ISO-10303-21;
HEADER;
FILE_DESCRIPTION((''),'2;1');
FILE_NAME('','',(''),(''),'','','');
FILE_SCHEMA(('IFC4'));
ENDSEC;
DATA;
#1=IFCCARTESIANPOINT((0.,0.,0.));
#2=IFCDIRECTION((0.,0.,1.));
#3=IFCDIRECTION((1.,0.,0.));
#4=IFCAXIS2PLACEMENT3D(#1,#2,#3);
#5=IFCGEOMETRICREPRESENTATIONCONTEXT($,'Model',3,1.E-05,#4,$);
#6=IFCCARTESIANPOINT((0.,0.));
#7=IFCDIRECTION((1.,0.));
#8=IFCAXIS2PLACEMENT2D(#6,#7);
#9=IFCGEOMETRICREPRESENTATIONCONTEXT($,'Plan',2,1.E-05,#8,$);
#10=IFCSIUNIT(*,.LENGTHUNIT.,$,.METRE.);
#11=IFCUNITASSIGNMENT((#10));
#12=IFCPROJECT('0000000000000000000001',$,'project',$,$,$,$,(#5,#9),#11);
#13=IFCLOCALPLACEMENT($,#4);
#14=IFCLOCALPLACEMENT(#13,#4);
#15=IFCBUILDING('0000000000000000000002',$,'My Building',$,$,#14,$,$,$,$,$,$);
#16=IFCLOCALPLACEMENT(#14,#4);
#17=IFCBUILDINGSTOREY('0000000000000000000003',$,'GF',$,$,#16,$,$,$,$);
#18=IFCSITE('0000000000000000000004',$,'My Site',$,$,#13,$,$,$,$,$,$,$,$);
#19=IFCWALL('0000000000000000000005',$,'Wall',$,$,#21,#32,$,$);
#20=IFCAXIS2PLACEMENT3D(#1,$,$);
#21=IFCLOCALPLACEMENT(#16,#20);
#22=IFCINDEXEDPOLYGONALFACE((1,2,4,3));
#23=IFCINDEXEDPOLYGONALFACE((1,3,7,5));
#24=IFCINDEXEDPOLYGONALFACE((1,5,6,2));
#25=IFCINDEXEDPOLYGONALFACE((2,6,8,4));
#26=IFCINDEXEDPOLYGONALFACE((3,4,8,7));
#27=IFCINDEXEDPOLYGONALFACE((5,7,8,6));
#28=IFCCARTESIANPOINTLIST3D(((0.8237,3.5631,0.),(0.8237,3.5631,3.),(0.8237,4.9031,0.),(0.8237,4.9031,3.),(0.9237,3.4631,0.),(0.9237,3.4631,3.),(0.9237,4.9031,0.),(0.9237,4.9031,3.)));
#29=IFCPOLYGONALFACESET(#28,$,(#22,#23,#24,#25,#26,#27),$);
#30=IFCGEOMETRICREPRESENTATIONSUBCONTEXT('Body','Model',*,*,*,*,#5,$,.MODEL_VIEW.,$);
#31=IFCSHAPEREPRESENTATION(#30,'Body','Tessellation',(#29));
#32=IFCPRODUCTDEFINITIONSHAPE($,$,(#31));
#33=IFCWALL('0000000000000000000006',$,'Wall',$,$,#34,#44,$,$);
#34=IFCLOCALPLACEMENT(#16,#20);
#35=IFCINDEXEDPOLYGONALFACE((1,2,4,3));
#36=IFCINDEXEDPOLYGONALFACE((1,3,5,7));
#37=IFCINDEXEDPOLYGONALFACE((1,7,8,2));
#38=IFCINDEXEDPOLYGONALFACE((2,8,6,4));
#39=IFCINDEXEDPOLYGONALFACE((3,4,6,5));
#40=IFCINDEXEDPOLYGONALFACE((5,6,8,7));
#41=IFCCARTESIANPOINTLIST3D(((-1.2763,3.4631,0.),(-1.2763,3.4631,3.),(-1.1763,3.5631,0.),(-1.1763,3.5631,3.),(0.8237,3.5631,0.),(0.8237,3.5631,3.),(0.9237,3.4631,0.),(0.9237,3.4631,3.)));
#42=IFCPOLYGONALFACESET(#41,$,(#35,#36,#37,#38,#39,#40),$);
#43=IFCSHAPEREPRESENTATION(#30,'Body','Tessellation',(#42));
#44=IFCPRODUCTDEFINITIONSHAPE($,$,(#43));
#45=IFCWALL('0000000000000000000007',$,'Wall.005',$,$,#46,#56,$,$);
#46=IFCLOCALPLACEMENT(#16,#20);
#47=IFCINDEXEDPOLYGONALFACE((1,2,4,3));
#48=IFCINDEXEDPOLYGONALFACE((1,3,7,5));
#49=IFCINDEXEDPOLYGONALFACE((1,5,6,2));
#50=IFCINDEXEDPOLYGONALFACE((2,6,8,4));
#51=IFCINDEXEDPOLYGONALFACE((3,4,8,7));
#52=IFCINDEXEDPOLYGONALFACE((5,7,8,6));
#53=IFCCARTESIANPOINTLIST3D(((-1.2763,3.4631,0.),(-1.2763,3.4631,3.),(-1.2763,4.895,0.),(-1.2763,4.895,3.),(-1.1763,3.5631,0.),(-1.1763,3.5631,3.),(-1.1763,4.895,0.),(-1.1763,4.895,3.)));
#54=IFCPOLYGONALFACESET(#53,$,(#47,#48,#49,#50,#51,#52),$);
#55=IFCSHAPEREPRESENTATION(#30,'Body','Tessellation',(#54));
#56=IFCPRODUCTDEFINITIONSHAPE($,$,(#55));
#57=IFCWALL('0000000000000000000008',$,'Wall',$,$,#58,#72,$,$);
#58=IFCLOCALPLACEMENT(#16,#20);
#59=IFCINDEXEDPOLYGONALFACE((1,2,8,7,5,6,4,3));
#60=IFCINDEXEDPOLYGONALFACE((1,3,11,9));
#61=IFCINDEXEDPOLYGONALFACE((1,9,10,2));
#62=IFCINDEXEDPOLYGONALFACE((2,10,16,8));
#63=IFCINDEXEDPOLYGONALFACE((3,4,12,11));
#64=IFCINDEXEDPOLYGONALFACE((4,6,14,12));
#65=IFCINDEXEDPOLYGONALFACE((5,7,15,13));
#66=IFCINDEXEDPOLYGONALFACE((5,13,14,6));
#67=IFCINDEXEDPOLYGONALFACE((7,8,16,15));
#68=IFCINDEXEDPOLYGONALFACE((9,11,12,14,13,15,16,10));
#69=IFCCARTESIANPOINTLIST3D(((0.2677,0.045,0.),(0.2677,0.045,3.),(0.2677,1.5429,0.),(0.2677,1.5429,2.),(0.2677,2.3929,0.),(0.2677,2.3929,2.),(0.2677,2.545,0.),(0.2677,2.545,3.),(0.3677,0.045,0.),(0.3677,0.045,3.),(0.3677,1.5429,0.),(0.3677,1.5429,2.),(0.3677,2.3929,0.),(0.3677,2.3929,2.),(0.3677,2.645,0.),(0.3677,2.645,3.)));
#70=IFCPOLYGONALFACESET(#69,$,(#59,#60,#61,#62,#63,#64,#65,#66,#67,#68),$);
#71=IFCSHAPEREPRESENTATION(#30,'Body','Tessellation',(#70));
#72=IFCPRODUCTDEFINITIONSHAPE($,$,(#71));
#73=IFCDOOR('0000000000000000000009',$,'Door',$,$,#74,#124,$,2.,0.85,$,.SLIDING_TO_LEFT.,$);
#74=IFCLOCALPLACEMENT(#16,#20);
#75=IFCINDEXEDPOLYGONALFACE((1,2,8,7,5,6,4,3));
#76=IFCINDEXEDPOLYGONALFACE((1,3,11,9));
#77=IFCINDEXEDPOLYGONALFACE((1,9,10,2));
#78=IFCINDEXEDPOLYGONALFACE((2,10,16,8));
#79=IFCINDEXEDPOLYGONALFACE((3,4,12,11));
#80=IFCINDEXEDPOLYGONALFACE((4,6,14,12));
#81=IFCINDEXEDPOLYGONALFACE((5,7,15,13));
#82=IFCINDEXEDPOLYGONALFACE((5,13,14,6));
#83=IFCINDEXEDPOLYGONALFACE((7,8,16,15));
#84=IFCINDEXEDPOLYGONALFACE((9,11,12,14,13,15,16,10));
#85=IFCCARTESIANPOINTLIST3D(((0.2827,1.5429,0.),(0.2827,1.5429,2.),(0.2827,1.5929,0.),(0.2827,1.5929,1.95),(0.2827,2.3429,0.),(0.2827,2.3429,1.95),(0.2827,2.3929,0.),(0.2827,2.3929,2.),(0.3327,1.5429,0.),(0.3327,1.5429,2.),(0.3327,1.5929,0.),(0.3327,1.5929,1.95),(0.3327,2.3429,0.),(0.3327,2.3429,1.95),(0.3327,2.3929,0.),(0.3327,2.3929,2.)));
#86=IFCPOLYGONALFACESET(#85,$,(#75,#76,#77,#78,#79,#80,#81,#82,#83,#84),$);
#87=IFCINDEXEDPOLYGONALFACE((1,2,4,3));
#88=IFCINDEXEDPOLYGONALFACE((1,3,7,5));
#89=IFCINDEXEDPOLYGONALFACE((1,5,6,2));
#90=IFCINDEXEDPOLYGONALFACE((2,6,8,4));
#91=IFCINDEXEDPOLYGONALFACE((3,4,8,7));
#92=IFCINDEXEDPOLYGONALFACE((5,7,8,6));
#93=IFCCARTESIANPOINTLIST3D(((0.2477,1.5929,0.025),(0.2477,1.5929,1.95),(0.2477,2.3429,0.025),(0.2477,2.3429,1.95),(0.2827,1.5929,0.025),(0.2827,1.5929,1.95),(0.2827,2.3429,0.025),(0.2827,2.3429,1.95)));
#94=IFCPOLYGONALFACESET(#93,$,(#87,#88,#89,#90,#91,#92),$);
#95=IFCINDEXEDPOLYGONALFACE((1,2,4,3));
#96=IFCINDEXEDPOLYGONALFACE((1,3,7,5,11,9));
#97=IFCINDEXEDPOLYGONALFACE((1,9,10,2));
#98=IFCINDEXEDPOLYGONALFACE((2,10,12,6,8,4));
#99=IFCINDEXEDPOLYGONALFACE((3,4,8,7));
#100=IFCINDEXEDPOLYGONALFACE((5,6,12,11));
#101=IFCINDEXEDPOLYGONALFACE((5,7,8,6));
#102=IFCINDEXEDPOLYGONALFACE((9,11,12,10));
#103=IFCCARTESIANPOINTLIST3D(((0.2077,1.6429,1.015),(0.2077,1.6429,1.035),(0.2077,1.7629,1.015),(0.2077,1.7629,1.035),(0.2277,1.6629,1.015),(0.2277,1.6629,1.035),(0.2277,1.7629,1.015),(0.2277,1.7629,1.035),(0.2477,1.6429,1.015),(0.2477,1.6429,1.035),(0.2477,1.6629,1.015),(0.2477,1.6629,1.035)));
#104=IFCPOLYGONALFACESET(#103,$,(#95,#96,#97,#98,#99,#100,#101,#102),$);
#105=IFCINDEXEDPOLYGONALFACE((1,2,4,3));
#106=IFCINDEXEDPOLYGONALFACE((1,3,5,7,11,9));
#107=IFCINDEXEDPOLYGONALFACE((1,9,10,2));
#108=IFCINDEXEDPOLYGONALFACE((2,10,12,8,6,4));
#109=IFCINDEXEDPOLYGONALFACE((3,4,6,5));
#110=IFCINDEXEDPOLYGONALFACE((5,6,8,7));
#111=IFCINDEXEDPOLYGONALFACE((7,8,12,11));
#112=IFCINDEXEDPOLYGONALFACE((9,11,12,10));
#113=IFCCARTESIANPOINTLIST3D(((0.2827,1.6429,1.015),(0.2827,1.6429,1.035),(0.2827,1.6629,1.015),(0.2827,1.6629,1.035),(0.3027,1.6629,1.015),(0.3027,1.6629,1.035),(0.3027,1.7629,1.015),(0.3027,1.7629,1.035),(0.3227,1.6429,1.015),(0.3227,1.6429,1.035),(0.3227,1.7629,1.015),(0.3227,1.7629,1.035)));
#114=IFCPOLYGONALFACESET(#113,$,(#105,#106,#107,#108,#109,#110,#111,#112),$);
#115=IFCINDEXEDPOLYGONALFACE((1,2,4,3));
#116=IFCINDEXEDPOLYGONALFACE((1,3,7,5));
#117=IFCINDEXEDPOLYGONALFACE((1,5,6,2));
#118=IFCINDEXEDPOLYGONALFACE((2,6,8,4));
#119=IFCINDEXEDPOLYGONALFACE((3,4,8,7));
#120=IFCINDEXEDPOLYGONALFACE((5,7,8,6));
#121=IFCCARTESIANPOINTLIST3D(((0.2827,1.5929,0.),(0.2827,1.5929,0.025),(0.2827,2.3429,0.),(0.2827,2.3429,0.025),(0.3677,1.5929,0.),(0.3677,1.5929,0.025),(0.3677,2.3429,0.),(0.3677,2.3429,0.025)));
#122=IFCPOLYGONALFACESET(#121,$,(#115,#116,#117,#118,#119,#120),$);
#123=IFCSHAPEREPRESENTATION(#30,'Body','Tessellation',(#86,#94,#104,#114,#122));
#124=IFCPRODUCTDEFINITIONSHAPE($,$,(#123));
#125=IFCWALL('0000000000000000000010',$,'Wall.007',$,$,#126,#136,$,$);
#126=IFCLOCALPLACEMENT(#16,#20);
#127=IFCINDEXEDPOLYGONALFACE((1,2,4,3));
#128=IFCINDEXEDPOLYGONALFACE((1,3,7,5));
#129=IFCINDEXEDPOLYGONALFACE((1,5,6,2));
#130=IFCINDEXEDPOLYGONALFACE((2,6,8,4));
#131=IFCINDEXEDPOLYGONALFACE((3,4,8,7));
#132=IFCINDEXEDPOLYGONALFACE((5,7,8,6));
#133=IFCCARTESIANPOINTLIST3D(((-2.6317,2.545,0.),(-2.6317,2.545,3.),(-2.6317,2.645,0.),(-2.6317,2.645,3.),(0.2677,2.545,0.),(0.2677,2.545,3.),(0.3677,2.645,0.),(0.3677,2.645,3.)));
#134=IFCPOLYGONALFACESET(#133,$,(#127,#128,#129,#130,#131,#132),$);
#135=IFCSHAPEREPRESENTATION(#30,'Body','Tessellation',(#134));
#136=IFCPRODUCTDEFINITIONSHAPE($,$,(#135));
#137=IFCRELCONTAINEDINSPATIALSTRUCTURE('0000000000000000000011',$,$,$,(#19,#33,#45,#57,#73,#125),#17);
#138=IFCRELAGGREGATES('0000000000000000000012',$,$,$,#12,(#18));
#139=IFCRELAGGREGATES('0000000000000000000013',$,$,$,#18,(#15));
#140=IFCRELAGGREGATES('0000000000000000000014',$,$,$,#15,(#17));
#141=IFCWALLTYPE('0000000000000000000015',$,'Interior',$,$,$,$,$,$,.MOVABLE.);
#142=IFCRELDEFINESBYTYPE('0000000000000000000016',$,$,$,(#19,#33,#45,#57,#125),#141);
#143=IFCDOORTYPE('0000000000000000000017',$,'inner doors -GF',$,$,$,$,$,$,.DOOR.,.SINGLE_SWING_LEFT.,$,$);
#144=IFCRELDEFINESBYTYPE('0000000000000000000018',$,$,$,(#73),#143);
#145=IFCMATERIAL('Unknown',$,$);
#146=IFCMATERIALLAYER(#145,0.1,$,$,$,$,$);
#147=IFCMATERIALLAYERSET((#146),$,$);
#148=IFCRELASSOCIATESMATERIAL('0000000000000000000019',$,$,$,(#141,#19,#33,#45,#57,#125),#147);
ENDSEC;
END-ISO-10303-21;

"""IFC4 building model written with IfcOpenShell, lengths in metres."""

from ifc_helpers import new_model, entity, si_unit, frame, origin_with_axes, origin_2d_with_axis, place, context, subcontext, project, spatial, line, indexed_curve, outline, extrude, shape, source, transform, mapped, material, layer, layer_set, layer_usage, type_object, type_shapes, element, fill, save


model = new_model("IFC4")

# Units and contexts
model_context = context("Model", 3, precision=1e-05, world=origin_with_axes())
plan_context = context("Plan", 2, precision=1e-05, world=origin_2d_with_axis())
body_context_1 = subcontext(model_context, "Body", "Model", "MODEL_VIEW")
body_context_2 = subcontext(plan_context, "Body", "Plan", "PLAN_VIEW")
ifc_project = project(units=[si_unit("LENGTHUNIT", "METRE")], contexts=[model_context, plan_context])

# Site, building, storey
site_placement = place(None, origin_with_axes())
site = spatial("IfcSite", under=ifc_project, at=site_placement, Name="My Site")
building_placement = place(site_placement, origin_with_axes())
building = spatial("IfcBuilding", under=site, at=building_placement, Name="My Building")
storey_placement = place(building_placement, origin_with_axes())
storey = spatial("IfcBuildingStorey", under=building, at=storey_placement, Name="GF")

# Shared definitions
ifc_material = material(Name="Unknown")

# Walls
ifc_layer_1 = layer(ifc_material, 0.1)
ifc_layer_set_1 = layer_set([ifc_layer_1])
ifc_layer_usage_1 = layer_usage(ifc_layer_set_1, "AXIS2", "POSITIVE", 0.0)
wall_type_1 = type_object("IfcWallType", Name="Interior", PredefinedType="MOVABLE", material=ifc_layer_set_1)
wall_1_placement = place(storey_placement, frame((0.8237, 4.9031, 0.0), z_axis=(0.0, 0.0, 1.0), x_axis=(0.0, -1.0, 0.0)))
element("IfcWall", 1, at=wall_1_placement, inside=storey, type_object=wall_type_1, material=ifc_layer_usage_1, Name="Wall", context=body_context_1, shape_type="SweptSolid", body=[
    extrude(outline(indexed_curve([(0.0, 0.0), (0.0, 0.1), (1.44, 0.1), (1.34, 0.0)], segments=[line(1, 2, 3, 4, 1)])), origin_with_axes(), (0.0, 0.0, 1.0), 3.0),
])
ifc_layer_usage_2 = layer_usage(ifc_layer_set_1, "AXIS2", "POSITIVE", 0.0)
wall_2_placement = place(storey_placement, frame((0.8237, 3.5631, 0.0), z_axis=(0.0, 0.0, 1.0), x_axis=(-1.0, 0.0, 0.0)))
element("IfcWall", 2, at=wall_2_placement, inside=storey, type_object=wall_type_1, material=ifc_layer_usage_2, Name="Wall", context=body_context_1, shape_type="SweptSolid", body=[
    extrude(outline(indexed_curve([(0.0, 0.0), (-0.1, 0.1), (2.1, 0.1), (2.0, 0.0)], segments=[line(1, 2, 3, 4, 1)])), origin_with_axes(), (0.0, 0.0, 1.0), 3.0),
])
ifc_layer_usage_3 = layer_usage(ifc_layer_set_1, "AXIS2", "POSITIVE", 0.0)
wall_3_placement = place(storey_placement, frame((-1.1763, 3.5631, 0.0), z_axis=(0.0, 0.0, 1.0), x_axis=(0.0, 1.0, 0.0)))
element("IfcWall", 3, at=wall_3_placement, inside=storey, type_object=wall_type_1, material=ifc_layer_usage_3, Name="Wall.005", context=body_context_1, shape_type="SweptSolid", body=[
    extrude(outline(indexed_curve([(0.0, 0.0), (-0.1, 0.1), (1.3318, 0.1), (1.3318, 0.0)], segments=[line(1, 2, 3, 4, 1)])), origin_with_axes(), (0.0, 0.0, 1.0), 3.0),
])

# Wall, opening, door
ifc_layer_usage_4 = layer_usage(ifc_layer_set_1, "AXIS2", "POSITIVE", 0.0)
wall_4_placement = place(storey_placement, frame((0.3677, 0.045, 0.0), z_axis=(0.0, 0.0, 1.0), x_axis=(0.0, 1.0, 0.0)))
wall_4 = element("IfcWall", 4, at=wall_4_placement, inside=storey, type_object=wall_type_1, material=ifc_layer_usage_4, Name="Wall", context=body_context_1, shape_type="SweptSolid", body=[
    extrude(outline(indexed_curve([(0.0, 0.0), (0.0, 0.1), (2.5, 0.1), (2.6, 0.0)], segments=[line(1, 2, 3, 4, 1)])), origin_with_axes(), (0.0, 0.0, 1.0), 3.0),
])
shared_shape_1 = source(origin_with_axes(), body_context_1, "Body", "SweptSolid", [
    extrude(outline(indexed_curve([(0.0, 0.0), (0.85, 0.0), (0.85, 2.0), (0.0, 2.0)], segments=[line(1, 2, 3, 4, 1)])), frame((0.0, -0.6, 0.0), z_axis=(0.0, -1.0, 0.0), x_axis=(1.0, 0.0, 0.0)), (0.0, 0.0, -1.0), 1.2),
])
opening_1_placement = place(wall_4_placement, frame((2.3479, 0.1, 0.0), z_axis=(0.0, 0.0, 1.0), x_axis=(-1.0, 0.0, 0.0)))
opening_1 = element("IfcOpeningElement", 5, at=opening_1_placement, cuts=wall_4, PredefinedType="OPENING", context=body_context_1, shape_type="MappedRepresentation", body=[
    mapped(shared_shape_1, transform((0.0, 0.0, 0.0), x_axis=(1.0, 0.0, 0.0), y_axis=(0.0, 1.0, 0.0), z_axis=(0.0, 0.0, 1.0), scale=1.0)),
])
door_type_1 = type_object("IfcDoorType", Name="inner doors -GF", OperationType="SINGLE_SWING_LEFT", PredefinedType="DOOR")
shared_shape_2 = source(origin_with_axes(), body_context_1, "Body", "SweptSolid", [
    extrude(outline(indexed_curve([(0.0, 0.0), (0.0, 2.0), (0.85, 2.0), (0.85, 0.0), (0.8, 0.0), (0.8, 1.95), (0.05, 1.95), (0.05, 0.0)], segments=[line(1, 2, 3, 4, 5, 6, 7, 8, 1)])), frame((0.0, 0.0, 0.0), z_axis=(0.0, -1.0, 0.0), x_axis=(1.0, 0.0, 0.0)), (0.0, 0.0, -1.0), 0.05),
    extrude(outline(indexed_curve([(0.0, 0.0), (0.75, 0.0), (0.75, 0.035), (0.0, 0.035)], segments=[line(1, 2, 3, 4, 1)])), frame((0.05, -0.035, 0.025), z_axis=(0.0, 0.0, 1.0), x_axis=(1.0, 0.0, 0.0)), (0.0, 0.0, 1.0), 1.925),
    extrude(outline(indexed_curve([(0.0, 0.0), (0.0, -0.04), (-0.12, -0.04), (-0.12, -0.02), (-0.02, -0.02), (-0.02, 0.0)], segments=[line(1, 2, 3, 4, 5, 6, 1)])), frame((0.75, -0.035, 1.015), z_axis=(0.0, 0.0, 1.0), x_axis=(1.0, 0.0, 0.0)), (0.0, 0.0, 1.0), 0.02),
    extrude(outline(indexed_curve([(0.0, 0.0), (0.0, 0.04), (-0.12, 0.04), (-0.12, 0.02), (-0.02, 0.02), (-0.02, 0.0)], segments=[line(1, 2, 3, 4, 5, 6, 1)])), frame((0.75, 0.0, 1.015), z_axis=(0.0, 0.0, 1.0), x_axis=(1.0, 0.0, 0.0)), (0.0, 0.0, 1.0), 0.02),
    extrude(outline(indexed_curve([(0.0, 0.0), (0.75, 0.0), (0.75, 0.085), (0.0, 0.085)], segments=[line(1, 2, 3, 4, 1)])), frame((0.05, 0.0, 0.0), z_axis=(0.0, 0.0, 1.0), x_axis=(1.0, 0.0, 0.0)), (0.0, 0.0, 1.0), 0.025),
])
shared_shape_3 = source(origin_with_axes(), body_context_2, "Body", "Curve2D", [
    entity("IfcIndexedPolyCurve", entity("IfcCartesianPointList2D", [[0.0, 0.0], [0.05, 0.0], [0.05, 0.05], [0.0, 0.05]]), [entity("IfcLineIndex", [1, 2, 3, 4, 1])]),
    entity("IfcIndexedPolyCurve", entity("IfcCartesianPointList2D", [[0.85, 0.0], [0.8, 0.0], [0.8, 0.05], [0.85, 0.05]]), [entity("IfcLineIndex", [1, 2, 3, 4, 1])]),
    entity("IfcIndexedPolyCurve", entity("IfcCartesianPointList2D", [[-0.325, -0.035], [0.425, -0.035], [0.425, 0.0], [-0.325, 0.0]]), [entity("IfcLineIndex", [1, 2, 3, 4, 1])]),
])
type_shapes(door_type_1, [shared_shape_2, shared_shape_3])
door_1_placement = place(opening_1_placement, frame((0.0, 0.015, 0.0), z_axis=(0.0, 0.0, 1.0), x_axis=(1.0, 0.0, 0.0)))
door_1 = element("IfcDoor", 6, at=door_1_placement, inside=storey, type_object=door_type_1, Name="Door", OperationType="SLIDING_TO_LEFT", OverallHeight=2.0, OverallWidth=0.85, shapes=[
    shape(body_context_1, "Body", "MappedRepresentation", [mapped(shared_shape_2, transform((0.0, 0.0, 0.0), x_axis=(1.0, 0.0, 0.0), y_axis=(0.0, 1.0, 0.0), z_axis=(0.0, 0.0, 1.0), scale=1.0))]),
    shape(body_context_2, "Body", "MappedRepresentation", [mapped(shared_shape_3, transform((0.0, 0.0, 0.0), x_axis=(1.0, 0.0, 0.0), y_axis=(0.0, 1.0, 0.0), z_axis=(0.0, 0.0, 1.0), scale=1.0))]),
])
fill(opening_1, door_1)

# Wall
ifc_layer_usage_5 = layer_usage(ifc_layer_set_1, "AXIS2", "POSITIVE", 0.0)
wall_5_placement = place(storey_placement, frame((0.3677, 2.645, 0.0), z_axis=(0.0, 0.0, 1.0), x_axis=(-1.0, 0.0, 0.0)))
element("IfcWall", 7, at=wall_5_placement, inside=storey, type_object=wall_type_1, material=ifc_layer_usage_5, Name="Wall.007", context=body_context_1, shape_type="SweptSolid", body=[
    extrude(outline(indexed_curve([(0.0, 0.0), (0.1, 0.1), (2.9994, 0.1), (2.9994, 0.0)], segments=[line(1, 2, 3, 4, 1)])), origin_with_axes(), (0.0, 0.0, 1.0), 3.0),
])

save(model, "model.ifc")
